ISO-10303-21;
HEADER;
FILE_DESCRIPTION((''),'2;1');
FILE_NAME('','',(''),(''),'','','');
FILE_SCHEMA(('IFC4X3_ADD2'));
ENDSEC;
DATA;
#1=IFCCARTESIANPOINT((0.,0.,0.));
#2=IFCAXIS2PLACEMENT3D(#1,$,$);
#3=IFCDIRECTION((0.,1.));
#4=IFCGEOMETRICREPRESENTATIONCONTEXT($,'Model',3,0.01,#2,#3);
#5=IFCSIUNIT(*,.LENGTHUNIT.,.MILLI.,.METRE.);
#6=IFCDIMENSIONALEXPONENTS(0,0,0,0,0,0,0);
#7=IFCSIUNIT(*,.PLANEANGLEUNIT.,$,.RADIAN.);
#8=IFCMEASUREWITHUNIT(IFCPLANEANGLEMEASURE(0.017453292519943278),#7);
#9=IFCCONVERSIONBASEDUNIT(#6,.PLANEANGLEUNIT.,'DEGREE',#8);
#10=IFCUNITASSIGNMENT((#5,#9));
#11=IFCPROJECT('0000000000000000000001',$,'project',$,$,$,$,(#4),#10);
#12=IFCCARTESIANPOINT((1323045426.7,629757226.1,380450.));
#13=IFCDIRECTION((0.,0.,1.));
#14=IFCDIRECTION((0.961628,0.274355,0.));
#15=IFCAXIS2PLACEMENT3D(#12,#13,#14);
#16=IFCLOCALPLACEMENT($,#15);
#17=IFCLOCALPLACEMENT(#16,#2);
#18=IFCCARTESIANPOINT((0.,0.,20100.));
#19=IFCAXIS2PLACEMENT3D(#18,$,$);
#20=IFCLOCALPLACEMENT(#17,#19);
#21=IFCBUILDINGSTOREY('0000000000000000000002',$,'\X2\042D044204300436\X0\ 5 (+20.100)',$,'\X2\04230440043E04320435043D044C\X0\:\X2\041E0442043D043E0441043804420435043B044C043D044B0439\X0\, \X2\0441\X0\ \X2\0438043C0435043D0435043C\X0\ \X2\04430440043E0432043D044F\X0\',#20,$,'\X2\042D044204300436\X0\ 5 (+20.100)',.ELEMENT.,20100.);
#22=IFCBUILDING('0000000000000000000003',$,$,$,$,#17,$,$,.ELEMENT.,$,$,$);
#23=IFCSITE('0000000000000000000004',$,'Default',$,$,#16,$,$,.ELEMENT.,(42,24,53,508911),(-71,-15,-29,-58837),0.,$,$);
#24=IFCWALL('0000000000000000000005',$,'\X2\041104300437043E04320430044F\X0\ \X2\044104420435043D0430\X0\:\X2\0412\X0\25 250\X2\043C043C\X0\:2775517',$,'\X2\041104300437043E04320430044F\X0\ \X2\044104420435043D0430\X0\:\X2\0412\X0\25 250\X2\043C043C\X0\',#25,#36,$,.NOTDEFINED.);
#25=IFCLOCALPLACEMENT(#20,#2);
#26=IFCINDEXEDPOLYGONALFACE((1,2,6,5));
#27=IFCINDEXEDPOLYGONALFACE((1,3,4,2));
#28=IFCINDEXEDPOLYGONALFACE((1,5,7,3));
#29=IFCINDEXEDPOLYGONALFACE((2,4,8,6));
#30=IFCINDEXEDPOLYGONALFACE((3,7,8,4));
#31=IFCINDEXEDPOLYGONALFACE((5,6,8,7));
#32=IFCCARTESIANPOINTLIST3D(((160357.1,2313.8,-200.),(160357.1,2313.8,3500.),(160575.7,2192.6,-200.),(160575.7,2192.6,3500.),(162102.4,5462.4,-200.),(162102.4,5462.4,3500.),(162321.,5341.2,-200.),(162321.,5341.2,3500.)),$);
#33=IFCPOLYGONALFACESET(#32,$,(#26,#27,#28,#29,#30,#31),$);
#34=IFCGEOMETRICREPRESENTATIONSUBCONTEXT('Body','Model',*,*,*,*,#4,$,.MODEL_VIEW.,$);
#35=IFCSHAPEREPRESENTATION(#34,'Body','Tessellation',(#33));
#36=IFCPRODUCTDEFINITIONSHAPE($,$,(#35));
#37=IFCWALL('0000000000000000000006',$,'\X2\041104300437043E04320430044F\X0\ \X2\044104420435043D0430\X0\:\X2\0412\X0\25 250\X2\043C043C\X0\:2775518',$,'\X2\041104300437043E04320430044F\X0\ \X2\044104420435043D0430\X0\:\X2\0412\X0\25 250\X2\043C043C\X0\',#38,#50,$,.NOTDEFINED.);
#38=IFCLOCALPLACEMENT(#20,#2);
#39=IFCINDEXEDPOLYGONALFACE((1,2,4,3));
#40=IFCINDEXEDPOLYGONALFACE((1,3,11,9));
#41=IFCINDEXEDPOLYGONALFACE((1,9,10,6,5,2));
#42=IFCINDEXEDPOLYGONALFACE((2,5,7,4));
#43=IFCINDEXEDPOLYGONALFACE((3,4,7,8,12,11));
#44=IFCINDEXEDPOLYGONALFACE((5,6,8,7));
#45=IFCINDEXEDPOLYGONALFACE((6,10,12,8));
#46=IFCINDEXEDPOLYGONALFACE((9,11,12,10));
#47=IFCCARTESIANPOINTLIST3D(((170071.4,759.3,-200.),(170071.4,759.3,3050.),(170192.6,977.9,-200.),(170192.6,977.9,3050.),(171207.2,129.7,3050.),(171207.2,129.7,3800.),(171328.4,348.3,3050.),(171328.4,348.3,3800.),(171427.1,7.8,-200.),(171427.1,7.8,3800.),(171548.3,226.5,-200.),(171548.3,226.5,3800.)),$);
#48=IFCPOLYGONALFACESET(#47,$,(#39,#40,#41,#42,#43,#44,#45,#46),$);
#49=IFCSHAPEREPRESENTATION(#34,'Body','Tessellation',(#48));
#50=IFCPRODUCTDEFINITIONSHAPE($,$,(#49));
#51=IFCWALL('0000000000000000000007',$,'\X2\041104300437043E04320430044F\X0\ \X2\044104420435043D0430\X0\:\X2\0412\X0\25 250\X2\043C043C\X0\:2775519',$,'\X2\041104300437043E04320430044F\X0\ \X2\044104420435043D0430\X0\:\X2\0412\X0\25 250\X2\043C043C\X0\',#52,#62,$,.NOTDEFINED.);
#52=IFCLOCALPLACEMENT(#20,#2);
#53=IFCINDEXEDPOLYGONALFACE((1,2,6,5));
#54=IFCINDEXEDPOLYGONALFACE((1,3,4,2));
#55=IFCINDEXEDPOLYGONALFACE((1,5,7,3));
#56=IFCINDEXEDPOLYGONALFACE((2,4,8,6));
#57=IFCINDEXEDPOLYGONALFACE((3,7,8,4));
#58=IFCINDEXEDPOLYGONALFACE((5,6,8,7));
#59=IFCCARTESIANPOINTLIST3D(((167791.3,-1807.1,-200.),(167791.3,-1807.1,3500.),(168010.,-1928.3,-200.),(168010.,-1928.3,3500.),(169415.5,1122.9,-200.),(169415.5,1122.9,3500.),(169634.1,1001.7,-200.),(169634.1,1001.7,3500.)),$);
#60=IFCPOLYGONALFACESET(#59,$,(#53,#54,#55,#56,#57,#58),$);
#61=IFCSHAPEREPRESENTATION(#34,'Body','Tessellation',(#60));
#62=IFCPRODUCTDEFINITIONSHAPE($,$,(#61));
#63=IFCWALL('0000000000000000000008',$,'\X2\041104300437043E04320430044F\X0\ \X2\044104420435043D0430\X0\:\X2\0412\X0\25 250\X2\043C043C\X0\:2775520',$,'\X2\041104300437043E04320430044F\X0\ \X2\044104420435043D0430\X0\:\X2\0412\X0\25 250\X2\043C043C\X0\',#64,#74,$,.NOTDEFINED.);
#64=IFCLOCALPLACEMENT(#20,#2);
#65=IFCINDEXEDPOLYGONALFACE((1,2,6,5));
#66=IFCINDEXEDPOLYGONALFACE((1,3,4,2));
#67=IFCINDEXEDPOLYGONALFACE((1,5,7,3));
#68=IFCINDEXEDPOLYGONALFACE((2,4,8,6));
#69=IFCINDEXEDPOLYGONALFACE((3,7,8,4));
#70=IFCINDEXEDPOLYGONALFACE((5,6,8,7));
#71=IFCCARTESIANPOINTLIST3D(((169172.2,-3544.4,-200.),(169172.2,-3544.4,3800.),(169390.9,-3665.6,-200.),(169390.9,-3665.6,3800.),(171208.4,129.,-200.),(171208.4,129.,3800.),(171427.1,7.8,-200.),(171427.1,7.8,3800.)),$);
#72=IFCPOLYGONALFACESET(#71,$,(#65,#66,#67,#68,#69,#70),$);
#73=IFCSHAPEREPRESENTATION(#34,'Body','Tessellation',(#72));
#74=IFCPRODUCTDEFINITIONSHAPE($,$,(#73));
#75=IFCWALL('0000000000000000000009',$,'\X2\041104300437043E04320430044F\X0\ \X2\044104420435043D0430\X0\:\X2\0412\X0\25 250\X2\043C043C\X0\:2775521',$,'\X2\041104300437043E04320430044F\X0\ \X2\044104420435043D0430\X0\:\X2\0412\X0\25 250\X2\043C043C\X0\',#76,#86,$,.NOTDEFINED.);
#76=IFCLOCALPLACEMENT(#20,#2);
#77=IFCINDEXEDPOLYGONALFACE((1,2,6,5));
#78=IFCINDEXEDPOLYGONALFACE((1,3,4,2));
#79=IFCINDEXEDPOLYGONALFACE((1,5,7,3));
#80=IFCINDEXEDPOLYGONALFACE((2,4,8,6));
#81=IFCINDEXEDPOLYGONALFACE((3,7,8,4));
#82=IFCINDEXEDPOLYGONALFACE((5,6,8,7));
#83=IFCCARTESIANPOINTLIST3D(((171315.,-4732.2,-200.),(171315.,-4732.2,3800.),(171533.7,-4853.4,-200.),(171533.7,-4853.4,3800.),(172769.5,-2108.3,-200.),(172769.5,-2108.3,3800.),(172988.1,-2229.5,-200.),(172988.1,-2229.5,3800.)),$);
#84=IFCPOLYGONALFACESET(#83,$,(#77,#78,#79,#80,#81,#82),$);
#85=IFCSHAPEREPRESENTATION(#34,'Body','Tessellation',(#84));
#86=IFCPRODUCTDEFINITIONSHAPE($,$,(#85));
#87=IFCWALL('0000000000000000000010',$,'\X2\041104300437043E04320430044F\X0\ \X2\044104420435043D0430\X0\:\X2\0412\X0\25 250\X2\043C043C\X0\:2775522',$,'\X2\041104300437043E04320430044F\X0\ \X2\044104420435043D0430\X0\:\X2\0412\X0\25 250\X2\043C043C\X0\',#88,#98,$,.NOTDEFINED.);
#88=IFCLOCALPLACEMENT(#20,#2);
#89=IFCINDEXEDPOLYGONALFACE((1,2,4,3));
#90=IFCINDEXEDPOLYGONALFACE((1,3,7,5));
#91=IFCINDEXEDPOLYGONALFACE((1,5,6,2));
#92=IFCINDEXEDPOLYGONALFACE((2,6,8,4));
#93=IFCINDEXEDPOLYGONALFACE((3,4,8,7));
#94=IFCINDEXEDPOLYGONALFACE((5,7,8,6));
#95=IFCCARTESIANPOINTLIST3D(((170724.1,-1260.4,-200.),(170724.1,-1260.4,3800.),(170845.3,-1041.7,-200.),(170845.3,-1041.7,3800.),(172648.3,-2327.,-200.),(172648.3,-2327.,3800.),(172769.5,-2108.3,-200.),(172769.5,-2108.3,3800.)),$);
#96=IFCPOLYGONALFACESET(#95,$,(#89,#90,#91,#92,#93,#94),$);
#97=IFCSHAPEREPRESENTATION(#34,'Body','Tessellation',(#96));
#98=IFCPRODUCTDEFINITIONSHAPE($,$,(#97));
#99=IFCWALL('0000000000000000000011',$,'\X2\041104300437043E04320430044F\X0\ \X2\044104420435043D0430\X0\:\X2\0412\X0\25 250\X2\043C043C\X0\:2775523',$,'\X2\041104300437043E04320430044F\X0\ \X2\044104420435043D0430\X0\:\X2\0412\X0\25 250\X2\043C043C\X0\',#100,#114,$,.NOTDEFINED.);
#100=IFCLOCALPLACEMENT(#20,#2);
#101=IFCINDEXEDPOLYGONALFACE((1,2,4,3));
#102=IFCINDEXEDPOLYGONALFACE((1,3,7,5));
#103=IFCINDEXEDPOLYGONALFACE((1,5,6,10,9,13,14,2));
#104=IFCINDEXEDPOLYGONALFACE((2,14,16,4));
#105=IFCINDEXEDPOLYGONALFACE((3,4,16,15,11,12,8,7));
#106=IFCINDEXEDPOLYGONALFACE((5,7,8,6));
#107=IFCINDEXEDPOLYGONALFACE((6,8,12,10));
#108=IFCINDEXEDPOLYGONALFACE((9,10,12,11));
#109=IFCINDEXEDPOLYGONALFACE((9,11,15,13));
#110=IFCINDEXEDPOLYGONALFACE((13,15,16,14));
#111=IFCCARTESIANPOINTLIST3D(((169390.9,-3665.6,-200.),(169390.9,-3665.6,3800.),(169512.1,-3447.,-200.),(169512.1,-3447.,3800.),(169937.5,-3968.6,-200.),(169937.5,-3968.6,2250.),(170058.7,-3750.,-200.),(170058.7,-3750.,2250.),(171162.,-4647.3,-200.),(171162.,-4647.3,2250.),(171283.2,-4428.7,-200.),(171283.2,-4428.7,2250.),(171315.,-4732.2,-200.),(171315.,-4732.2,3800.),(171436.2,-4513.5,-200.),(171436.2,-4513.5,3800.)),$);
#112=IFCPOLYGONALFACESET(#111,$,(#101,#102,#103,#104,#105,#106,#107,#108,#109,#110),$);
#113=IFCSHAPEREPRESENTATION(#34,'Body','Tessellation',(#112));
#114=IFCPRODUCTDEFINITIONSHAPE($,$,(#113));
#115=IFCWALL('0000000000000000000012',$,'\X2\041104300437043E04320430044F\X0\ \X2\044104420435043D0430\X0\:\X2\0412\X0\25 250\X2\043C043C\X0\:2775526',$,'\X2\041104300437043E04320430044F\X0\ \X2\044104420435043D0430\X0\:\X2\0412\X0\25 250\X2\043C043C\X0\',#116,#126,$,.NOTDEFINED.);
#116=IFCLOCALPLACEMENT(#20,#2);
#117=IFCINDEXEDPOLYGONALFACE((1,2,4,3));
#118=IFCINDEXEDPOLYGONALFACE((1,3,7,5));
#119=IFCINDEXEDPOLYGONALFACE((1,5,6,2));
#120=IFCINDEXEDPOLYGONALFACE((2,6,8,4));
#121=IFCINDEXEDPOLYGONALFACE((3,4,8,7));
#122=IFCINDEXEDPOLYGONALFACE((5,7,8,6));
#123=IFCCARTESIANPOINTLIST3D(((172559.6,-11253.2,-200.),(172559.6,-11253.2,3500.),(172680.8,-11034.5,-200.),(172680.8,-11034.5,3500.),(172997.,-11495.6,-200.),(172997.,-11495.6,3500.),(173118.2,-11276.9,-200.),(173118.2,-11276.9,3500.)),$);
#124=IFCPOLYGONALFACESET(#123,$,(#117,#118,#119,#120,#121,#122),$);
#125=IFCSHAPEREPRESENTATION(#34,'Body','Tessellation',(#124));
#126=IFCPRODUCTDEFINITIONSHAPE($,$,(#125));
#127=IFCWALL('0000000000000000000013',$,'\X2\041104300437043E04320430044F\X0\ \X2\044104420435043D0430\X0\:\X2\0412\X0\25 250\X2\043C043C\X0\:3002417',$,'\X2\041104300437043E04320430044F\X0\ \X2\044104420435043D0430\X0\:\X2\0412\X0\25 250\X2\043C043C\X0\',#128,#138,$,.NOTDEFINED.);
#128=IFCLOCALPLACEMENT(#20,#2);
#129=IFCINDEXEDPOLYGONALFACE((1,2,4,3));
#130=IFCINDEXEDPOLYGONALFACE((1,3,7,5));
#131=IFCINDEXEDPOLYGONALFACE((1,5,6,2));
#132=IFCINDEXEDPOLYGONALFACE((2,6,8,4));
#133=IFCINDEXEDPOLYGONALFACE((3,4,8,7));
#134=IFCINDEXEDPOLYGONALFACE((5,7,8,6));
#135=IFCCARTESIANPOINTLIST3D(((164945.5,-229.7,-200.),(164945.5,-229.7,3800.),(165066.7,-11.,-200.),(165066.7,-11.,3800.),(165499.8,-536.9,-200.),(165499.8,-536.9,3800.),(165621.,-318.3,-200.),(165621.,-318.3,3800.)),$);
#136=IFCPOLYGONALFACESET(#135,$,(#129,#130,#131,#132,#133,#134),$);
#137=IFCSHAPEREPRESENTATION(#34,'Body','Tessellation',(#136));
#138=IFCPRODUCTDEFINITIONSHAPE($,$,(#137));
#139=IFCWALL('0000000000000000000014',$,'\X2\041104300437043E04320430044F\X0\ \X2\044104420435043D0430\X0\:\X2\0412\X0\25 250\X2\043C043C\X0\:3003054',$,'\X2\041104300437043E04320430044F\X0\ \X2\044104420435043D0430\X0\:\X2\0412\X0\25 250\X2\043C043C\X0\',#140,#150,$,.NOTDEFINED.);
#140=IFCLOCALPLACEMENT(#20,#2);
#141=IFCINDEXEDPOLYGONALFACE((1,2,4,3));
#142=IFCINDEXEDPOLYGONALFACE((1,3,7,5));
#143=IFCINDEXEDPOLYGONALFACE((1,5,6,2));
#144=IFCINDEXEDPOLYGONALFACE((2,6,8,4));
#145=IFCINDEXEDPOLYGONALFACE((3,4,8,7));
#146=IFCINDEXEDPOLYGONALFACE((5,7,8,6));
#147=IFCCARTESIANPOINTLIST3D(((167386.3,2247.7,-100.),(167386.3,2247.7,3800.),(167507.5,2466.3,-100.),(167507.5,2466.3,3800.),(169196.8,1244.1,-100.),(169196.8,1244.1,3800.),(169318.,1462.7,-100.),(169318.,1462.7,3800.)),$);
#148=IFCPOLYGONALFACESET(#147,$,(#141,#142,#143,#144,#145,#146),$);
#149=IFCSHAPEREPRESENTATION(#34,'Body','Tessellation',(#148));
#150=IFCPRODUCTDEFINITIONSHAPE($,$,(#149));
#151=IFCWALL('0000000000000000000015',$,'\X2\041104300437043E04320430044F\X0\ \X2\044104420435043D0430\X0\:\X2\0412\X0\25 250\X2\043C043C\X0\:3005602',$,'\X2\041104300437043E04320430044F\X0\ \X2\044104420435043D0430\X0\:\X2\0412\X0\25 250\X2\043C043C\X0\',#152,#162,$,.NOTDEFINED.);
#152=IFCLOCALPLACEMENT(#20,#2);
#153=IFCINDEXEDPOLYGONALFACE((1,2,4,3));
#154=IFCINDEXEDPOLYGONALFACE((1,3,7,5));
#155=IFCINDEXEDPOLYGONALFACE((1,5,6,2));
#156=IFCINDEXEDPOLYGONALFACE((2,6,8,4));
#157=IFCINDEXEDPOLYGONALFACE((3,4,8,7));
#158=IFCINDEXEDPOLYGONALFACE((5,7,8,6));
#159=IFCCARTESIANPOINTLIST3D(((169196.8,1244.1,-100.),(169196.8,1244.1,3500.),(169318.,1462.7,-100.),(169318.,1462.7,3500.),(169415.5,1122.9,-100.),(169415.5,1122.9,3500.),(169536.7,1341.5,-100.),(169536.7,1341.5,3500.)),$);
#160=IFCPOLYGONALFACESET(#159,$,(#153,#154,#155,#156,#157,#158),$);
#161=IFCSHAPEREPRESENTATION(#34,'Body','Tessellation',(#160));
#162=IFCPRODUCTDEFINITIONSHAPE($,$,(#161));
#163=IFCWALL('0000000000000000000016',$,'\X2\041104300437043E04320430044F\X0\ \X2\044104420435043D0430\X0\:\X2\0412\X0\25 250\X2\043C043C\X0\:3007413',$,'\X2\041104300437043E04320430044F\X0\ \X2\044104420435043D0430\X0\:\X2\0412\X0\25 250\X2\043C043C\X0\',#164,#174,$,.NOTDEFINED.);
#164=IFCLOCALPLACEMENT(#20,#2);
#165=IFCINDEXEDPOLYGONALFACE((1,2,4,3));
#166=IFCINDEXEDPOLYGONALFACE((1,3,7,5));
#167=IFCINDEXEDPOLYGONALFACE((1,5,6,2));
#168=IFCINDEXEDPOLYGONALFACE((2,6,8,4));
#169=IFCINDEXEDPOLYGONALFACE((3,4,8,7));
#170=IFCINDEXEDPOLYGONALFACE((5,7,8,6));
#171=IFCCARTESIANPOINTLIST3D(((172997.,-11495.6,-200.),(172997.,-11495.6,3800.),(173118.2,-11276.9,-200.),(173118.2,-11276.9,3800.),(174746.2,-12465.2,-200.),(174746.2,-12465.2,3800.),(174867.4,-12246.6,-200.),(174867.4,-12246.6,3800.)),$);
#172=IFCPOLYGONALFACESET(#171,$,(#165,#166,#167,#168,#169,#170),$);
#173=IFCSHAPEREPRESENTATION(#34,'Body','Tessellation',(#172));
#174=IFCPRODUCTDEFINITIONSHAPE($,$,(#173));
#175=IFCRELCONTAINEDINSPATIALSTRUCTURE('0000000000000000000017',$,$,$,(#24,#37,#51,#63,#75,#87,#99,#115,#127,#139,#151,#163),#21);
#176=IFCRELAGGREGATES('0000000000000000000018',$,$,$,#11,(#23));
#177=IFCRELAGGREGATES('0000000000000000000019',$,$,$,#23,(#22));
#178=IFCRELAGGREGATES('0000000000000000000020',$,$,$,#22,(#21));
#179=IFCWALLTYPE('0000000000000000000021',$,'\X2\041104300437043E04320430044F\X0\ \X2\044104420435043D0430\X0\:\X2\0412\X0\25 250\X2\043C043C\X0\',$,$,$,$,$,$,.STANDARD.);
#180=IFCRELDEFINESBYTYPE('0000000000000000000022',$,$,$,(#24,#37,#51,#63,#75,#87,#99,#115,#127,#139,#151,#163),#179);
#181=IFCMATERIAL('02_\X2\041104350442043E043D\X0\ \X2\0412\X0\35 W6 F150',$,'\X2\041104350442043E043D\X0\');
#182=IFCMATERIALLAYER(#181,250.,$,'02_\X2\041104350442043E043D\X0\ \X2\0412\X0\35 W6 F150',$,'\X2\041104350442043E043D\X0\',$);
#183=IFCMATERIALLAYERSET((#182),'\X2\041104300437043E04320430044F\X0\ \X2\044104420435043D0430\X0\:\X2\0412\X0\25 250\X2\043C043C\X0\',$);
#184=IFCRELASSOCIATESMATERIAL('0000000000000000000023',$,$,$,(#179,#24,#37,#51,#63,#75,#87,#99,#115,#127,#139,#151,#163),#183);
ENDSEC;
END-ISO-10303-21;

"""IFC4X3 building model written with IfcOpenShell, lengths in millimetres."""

from ifc_helpers import new_model, entity, si_unit, converted_unit, direction, frame, frame_2d, origin, place, context, subcontext, project, spatial, rectangle, extrude, material, layer, layer_set, type_object, element, save


model = new_model("IFC4X3")

# Units and contexts
model_context = context("Model", 3, precision=0.01, world=origin(), true_north=direction((0.0, 1.0)))
body_context = subcontext(model_context, "Body", "Model", "MODEL_VIEW")
ifc_project = project(units=[si_unit("LENGTHUNIT", "METRE", prefix="MILLI"), converted_unit("PLANEANGLEUNIT", "DEGREE", entity("IfcPlaneAngleMeasure", 0.017453292519943278), si_unit("PLANEANGLEUNIT", "RADIAN"), dimensions=[0, 0, 0, 0, 0, 0, 0])], contexts=[model_context])

# Site, building, storey
site_placement = place(None, frame((1323045426.7, 629757226.1, 380450.0), z_axis=(0.0, 0.0, 1.0), x_axis=(0.961628, 0.274355, 0.0)))
site = spatial("IfcSite", under=ifc_project, at=site_placement, Name="Default", CompositionType="ELEMENT", RefLatitude=(42, 24, 53, 508911), RefLongitude=(-71, -15, -29, -58837), RefElevation=0.0)
building_placement = place(site_placement, origin())
building = spatial("IfcBuilding", under=site, at=building_placement, CompositionType="ELEMENT")
storey_placement = place(building_placement, frame((0.0, 0.0, 20100.0)))
storey = spatial("IfcBuildingStorey", under=building, at=storey_placement, Name="Этаж 5 (+20.100)", ObjectType="Уровень:Относительный, с именем уровня", LongName="Этаж 5 (+20.100)", CompositionType="ELEMENT", Elevation=20100.0)

# Wall
ifc_material = material(Name="02_Бетон В35 W6 F150", Category="Бетон")
ifc_layer = layer(ifc_material, 250.0, Name="02_Бетон В35 W6 F150", Category="Бетон")
ifc_layer_set = layer_set([ifc_layer], Name="Базовая стена:В25 250мм")
wall_type = type_object("IfcWallType", Name="Базовая стена:В25 250мм", PredefinedType="STANDARD", material=ifc_layer_set)
wall_1_placement = place(storey_placement, frame((160466.4, 2253.2, -200.0), z_axis=(0.0, 0.0, 1.0), x_axis=(0.48481, 0.87462, 0.0)))
element("IfcWall", 1, at=wall_1_placement, inside=storey, type_object=wall_type, material=ifc_layer_set, Name="Базовая стена:В25 250мм:2775517", ObjectType="Базовая стена:В25 250мм", PredefinedType="NOTDEFINED", context=body_context, shape_type="SweptSolid", body=[
    extrude(rectangle(XDim=3600.0, YDim=250.0, at=frame_2d((1800.0, 0.0), x_axis=(-1.0, 0.0))), origin(), (0.0, 0.0, 1.0), 3700.0),
])

# Wall, opening
wall_2_placement = place(storey_placement, frame((171487.7, 117.1, -200.0), z_axis=(0.0, 0.0, 1.0), x_axis=(-0.87462, 0.48481, 0.0)))
wall_2 = element("IfcWall", 2, at=wall_2_placement, inside=storey, type_object=wall_type, material=ifc_layer_set, Name="Базовая стена:В25 250мм:2775518", ObjectType="Базовая стена:В25 250мм", PredefinedType="NOTDEFINED", context=body_context, shape_type="SweptSolid", body=[
    extrude(rectangle(XDim=1550.0, YDim=250.0, at=frame_2d((775.0, 0.0), x_axis=(-1.0, 0.0))), origin(), (0.0, 0.0, 1.0), 4000.0),
])
opening_1_placement = place(wall_2_placement, frame((149929.7, 83241.3, 3250.0), z_axis=(0.0, 0.0, 1.0), x_axis=(-0.87462, -0.48481, 0.0)))
element("IfcOpeningElement", 3, at=opening_1_placement, cuts=wall_2, PredefinedType="OPENING", context=body_context, shape_type="SweptSolid", body=[
    extrude(rectangle(XDim=750.0, YDim=1300.0, at=frame_2d((0.0, 0.0), x_axis=(0.0, 1.0))), frame((171498.7, 1996.4, 375.0), z_axis=(-0.48481, -0.87462, 0.0), x_axis=(-0.87462, 0.48481, 0.0)), (0.0, 0.0, 1.0), 3048.0),
])

# Walls
wall_3_placement = place(storey_placement, frame((167900.7, -1867.7, -200.0), z_axis=(0.0, 0.0, 1.0), x_axis=(0.48481, 0.87462, 0.0)))
element("IfcWall", 4, at=wall_3_placement, inside=storey, type_object=wall_type, material=ifc_layer_set, Name="Базовая стена:В25 250мм:2775519", ObjectType="Базовая стена:В25 250мм", PredefinedType="NOTDEFINED", context=body_context, shape_type="SweptSolid", body=[
    extrude(rectangle(XDim=3350.0, YDim=250.0, at=frame_2d((1675.0, 0.0), x_axis=(-1.0, 0.0))), origin(), (0.0, 0.0, 1.0), 3700.0),
])
wall_4_placement = place(storey_placement, frame((169281.5, -3605.0, -200.0), z_axis=(0.0, 0.0, 1.0), x_axis=(0.48481, 0.87462, 0.0)))
element("IfcWall", 5, at=wall_4_placement, inside=storey, type_object=wall_type, material=ifc_layer_set, Name="Базовая стена:В25 250мм:2775520", ObjectType="Базовая стена:В25 250мм", PredefinedType="NOTDEFINED", context=body_context, shape_type="SweptSolid", body=[
    extrude(rectangle(XDim=4200.0, YDim=250.0, at=frame_2d((2100.0, 0.0), x_axis=(-1.0, 0.0))), origin(), (0.0, 0.0, 1.0), 4000.0),
])
wall_5_placement = place(storey_placement, frame((171424.4, -4792.8, -200.0), z_axis=(0.0, 0.0, 1.0), x_axis=(0.48481, 0.87462, 0.0)))
element("IfcWall", 6, at=wall_5_placement, inside=storey, type_object=wall_type, material=ifc_layer_set, Name="Базовая стена:В25 250мм:2775521", ObjectType="Базовая стена:В25 250мм", PredefinedType="NOTDEFINED", context=body_context, shape_type="SweptSolid", body=[
    extrude(rectangle(XDim=3000.0, YDim=250.0, at=frame_2d((1500.0, 0.0), x_axis=(-1.0, 0.0))), origin(), (0.0, 0.0, 1.0), 4000.0),
])
wall_6_placement = place(storey_placement, frame((172708.9, -2217.7, -200.0), z_axis=(0.0, 0.0, 1.0), x_axis=(-0.87462, 0.48481, 0.0)))
element("IfcWall", 7, at=wall_6_placement, inside=storey, type_object=wall_type, material=ifc_layer_set, Name="Базовая стена:В25 250мм:2775522", ObjectType="Базовая стена:В25 250мм", PredefinedType="NOTDEFINED", context=body_context, shape_type="SweptSolid", body=[
    extrude(rectangle(XDim=2200.0, YDim=250.0, at=frame_2d((1100.0, 0.0), x_axis=(-1.0, 0.0))), origin(), (0.0, 0.0, 1.0), 4000.0),
])

# Wall, opening
wall_7_placement = place(storey_placement, frame((171375.6, -4622.9, -200.0), z_axis=(0.0, 0.0, 1.0), x_axis=(-0.87462, 0.48481, 0.0)))
wall_7 = element("IfcWall", 8, at=wall_7_placement, inside=storey, type_object=wall_type, material=ifc_layer_set, Name="Базовая стена:В25 250мм:2775523", ObjectType="Базовая стена:В25 250мм", PredefinedType="NOTDEFINED", context=body_context, shape_type="SweptSolid", body=[
    extrude(rectangle(XDim=2200.0, YDim=250.0, at=frame_2d((1100.0, 0.0), x_axis=(-1.0, 0.0))), origin(), (0.0, 0.0, 1.0), 4000.0),
])
opening_2_placement = place(wall_7_placement, frame((152129.7, 79041.3, 0.0), z_axis=(0.0, 0.0, 1.0), x_axis=(-0.87462, -0.48481, 0.0)))
element("IfcOpeningElement", 9, at=opening_2_placement, cuts=wall_7, PredefinedType="OPENING", context=body_context, shape_type="SweptSolid", body=[
    extrude(rectangle(XDim=2450.0, YDim=1400.0, at=frame_2d((0.0, 0.0), x_axis=(1.0, 0.0))), frame((171409.8, -2756.4, 1225.0), z_axis=(-0.48481, -0.87462, 0.0), x_axis=(0.0, 0.0, -1.0)), (0.0, 0.0, 1.0), 3048.0),
])

# Wall
wall_8_placement = place(storey_placement, frame((172620.2, -11143.9, -200.0), z_axis=(0.0, 0.0, 1.0), x_axis=(0.87462, -0.48481, 0.0)))
element("IfcWall", 10, at=wall_8_placement, inside=storey, type_object=wall_type, material=ifc_layer_set, Name="Базовая стена:В25 250мм:2775526", ObjectType="Базовая стена:В25 250мм", PredefinedType="NOTDEFINED", context=body_context, shape_type="SweptSolid", body=[
    extrude(rectangle(XDim=500.0, YDim=250.0, at=frame_2d((250.0, 0.0), x_axis=(-1.0, 0.0))), origin(), (0.0, 0.0, 1.0), 3700.0),
])

# Wall
wall_9_placement = place(storey_placement, frame((165006.1, -120.3, -200.0), z_axis=(0.0, 0.0, 1.0), x_axis=(0.87462, -0.48481, 0.0)))
element("IfcWall", 11, at=wall_9_placement, inside=storey, type_object=wall_type, material=ifc_layer_set, Name="Базовая стена:В25 250мм:3002417", ObjectType="Базовая стена:В25 250мм", PredefinedType="NOTDEFINED", context=body_context, shape_type="SweptSolid", body=[
    extrude(rectangle(XDim=633.8, YDim=250.0, at=frame_2d((316.9, 0.0), x_axis=(-1.0, 0.0))), origin(), (0.0, 0.0, 1.0), 4000.0),
])

# Wall
wall_10_placement = place(storey_placement, frame((169257.4, 1353.4, -100.0), z_axis=(0.0, 0.0, 1.0), x_axis=(-0.87462, 0.48481, 0.0)))
element("IfcWall", 12, at=wall_10_placement, inside=storey, type_object=wall_type, material=ifc_layer_set, Name="Базовая стена:В25 250мм:3003054", ObjectType="Базовая стена:В25 250мм", PredefinedType="NOTDEFINED", context=body_context, shape_type="SweptSolid", body=[
    extrude(rectangle(XDim=2070.1, YDim=250.0, at=frame_2d((1035.0, 0.0), x_axis=(-1.0, 0.0))), origin(), (0.0, 0.0, 1.0), 3900.0),
])

# Walls
wall_11_placement = place(storey_placement, frame((169476.1, 1232.2, -100.0), z_axis=(0.0, 0.0, 1.0), x_axis=(-0.87462, 0.48481, 0.0)))
element("IfcWall", 13, at=wall_11_placement, inside=storey, type_object=wall_type, material=ifc_layer_set, Name="Базовая стена:В25 250мм:3005602", ObjectType="Базовая стена:В25 250мм", PredefinedType="NOTDEFINED", context=body_context, shape_type="SweptSolid", body=[
    extrude(rectangle(XDim=250.0, YDim=250.0, at=frame_2d((125.0, 0.0), x_axis=(-1.0, 0.0))), origin(), (0.0, 0.0, 1.0), 3600.0),
])
wall_12_placement = place(storey_placement, frame((173057.6, -11386.3, -200.0), z_axis=(0.0, 0.0, 1.0), x_axis=(0.87462, -0.48481, 0.0)))
element("IfcWall", 14, at=wall_12_placement, inside=storey, type_object=wall_type, material=ifc_layer_set, Name="Базовая стена:В25 250мм:3007413", ObjectType="Базовая стена:В25 250мм", PredefinedType="NOTDEFINED", context=body_context, shape_type="SweptSolid", body=[
    extrude(rectangle(XDim=2000.0, YDim=250.0, at=frame_2d((1000.0, 0.0), x_axis=(-1.0, 0.0))), origin(), (0.0, 0.0, 1.0), 4000.0),
])

save(model, "model.ifc")
